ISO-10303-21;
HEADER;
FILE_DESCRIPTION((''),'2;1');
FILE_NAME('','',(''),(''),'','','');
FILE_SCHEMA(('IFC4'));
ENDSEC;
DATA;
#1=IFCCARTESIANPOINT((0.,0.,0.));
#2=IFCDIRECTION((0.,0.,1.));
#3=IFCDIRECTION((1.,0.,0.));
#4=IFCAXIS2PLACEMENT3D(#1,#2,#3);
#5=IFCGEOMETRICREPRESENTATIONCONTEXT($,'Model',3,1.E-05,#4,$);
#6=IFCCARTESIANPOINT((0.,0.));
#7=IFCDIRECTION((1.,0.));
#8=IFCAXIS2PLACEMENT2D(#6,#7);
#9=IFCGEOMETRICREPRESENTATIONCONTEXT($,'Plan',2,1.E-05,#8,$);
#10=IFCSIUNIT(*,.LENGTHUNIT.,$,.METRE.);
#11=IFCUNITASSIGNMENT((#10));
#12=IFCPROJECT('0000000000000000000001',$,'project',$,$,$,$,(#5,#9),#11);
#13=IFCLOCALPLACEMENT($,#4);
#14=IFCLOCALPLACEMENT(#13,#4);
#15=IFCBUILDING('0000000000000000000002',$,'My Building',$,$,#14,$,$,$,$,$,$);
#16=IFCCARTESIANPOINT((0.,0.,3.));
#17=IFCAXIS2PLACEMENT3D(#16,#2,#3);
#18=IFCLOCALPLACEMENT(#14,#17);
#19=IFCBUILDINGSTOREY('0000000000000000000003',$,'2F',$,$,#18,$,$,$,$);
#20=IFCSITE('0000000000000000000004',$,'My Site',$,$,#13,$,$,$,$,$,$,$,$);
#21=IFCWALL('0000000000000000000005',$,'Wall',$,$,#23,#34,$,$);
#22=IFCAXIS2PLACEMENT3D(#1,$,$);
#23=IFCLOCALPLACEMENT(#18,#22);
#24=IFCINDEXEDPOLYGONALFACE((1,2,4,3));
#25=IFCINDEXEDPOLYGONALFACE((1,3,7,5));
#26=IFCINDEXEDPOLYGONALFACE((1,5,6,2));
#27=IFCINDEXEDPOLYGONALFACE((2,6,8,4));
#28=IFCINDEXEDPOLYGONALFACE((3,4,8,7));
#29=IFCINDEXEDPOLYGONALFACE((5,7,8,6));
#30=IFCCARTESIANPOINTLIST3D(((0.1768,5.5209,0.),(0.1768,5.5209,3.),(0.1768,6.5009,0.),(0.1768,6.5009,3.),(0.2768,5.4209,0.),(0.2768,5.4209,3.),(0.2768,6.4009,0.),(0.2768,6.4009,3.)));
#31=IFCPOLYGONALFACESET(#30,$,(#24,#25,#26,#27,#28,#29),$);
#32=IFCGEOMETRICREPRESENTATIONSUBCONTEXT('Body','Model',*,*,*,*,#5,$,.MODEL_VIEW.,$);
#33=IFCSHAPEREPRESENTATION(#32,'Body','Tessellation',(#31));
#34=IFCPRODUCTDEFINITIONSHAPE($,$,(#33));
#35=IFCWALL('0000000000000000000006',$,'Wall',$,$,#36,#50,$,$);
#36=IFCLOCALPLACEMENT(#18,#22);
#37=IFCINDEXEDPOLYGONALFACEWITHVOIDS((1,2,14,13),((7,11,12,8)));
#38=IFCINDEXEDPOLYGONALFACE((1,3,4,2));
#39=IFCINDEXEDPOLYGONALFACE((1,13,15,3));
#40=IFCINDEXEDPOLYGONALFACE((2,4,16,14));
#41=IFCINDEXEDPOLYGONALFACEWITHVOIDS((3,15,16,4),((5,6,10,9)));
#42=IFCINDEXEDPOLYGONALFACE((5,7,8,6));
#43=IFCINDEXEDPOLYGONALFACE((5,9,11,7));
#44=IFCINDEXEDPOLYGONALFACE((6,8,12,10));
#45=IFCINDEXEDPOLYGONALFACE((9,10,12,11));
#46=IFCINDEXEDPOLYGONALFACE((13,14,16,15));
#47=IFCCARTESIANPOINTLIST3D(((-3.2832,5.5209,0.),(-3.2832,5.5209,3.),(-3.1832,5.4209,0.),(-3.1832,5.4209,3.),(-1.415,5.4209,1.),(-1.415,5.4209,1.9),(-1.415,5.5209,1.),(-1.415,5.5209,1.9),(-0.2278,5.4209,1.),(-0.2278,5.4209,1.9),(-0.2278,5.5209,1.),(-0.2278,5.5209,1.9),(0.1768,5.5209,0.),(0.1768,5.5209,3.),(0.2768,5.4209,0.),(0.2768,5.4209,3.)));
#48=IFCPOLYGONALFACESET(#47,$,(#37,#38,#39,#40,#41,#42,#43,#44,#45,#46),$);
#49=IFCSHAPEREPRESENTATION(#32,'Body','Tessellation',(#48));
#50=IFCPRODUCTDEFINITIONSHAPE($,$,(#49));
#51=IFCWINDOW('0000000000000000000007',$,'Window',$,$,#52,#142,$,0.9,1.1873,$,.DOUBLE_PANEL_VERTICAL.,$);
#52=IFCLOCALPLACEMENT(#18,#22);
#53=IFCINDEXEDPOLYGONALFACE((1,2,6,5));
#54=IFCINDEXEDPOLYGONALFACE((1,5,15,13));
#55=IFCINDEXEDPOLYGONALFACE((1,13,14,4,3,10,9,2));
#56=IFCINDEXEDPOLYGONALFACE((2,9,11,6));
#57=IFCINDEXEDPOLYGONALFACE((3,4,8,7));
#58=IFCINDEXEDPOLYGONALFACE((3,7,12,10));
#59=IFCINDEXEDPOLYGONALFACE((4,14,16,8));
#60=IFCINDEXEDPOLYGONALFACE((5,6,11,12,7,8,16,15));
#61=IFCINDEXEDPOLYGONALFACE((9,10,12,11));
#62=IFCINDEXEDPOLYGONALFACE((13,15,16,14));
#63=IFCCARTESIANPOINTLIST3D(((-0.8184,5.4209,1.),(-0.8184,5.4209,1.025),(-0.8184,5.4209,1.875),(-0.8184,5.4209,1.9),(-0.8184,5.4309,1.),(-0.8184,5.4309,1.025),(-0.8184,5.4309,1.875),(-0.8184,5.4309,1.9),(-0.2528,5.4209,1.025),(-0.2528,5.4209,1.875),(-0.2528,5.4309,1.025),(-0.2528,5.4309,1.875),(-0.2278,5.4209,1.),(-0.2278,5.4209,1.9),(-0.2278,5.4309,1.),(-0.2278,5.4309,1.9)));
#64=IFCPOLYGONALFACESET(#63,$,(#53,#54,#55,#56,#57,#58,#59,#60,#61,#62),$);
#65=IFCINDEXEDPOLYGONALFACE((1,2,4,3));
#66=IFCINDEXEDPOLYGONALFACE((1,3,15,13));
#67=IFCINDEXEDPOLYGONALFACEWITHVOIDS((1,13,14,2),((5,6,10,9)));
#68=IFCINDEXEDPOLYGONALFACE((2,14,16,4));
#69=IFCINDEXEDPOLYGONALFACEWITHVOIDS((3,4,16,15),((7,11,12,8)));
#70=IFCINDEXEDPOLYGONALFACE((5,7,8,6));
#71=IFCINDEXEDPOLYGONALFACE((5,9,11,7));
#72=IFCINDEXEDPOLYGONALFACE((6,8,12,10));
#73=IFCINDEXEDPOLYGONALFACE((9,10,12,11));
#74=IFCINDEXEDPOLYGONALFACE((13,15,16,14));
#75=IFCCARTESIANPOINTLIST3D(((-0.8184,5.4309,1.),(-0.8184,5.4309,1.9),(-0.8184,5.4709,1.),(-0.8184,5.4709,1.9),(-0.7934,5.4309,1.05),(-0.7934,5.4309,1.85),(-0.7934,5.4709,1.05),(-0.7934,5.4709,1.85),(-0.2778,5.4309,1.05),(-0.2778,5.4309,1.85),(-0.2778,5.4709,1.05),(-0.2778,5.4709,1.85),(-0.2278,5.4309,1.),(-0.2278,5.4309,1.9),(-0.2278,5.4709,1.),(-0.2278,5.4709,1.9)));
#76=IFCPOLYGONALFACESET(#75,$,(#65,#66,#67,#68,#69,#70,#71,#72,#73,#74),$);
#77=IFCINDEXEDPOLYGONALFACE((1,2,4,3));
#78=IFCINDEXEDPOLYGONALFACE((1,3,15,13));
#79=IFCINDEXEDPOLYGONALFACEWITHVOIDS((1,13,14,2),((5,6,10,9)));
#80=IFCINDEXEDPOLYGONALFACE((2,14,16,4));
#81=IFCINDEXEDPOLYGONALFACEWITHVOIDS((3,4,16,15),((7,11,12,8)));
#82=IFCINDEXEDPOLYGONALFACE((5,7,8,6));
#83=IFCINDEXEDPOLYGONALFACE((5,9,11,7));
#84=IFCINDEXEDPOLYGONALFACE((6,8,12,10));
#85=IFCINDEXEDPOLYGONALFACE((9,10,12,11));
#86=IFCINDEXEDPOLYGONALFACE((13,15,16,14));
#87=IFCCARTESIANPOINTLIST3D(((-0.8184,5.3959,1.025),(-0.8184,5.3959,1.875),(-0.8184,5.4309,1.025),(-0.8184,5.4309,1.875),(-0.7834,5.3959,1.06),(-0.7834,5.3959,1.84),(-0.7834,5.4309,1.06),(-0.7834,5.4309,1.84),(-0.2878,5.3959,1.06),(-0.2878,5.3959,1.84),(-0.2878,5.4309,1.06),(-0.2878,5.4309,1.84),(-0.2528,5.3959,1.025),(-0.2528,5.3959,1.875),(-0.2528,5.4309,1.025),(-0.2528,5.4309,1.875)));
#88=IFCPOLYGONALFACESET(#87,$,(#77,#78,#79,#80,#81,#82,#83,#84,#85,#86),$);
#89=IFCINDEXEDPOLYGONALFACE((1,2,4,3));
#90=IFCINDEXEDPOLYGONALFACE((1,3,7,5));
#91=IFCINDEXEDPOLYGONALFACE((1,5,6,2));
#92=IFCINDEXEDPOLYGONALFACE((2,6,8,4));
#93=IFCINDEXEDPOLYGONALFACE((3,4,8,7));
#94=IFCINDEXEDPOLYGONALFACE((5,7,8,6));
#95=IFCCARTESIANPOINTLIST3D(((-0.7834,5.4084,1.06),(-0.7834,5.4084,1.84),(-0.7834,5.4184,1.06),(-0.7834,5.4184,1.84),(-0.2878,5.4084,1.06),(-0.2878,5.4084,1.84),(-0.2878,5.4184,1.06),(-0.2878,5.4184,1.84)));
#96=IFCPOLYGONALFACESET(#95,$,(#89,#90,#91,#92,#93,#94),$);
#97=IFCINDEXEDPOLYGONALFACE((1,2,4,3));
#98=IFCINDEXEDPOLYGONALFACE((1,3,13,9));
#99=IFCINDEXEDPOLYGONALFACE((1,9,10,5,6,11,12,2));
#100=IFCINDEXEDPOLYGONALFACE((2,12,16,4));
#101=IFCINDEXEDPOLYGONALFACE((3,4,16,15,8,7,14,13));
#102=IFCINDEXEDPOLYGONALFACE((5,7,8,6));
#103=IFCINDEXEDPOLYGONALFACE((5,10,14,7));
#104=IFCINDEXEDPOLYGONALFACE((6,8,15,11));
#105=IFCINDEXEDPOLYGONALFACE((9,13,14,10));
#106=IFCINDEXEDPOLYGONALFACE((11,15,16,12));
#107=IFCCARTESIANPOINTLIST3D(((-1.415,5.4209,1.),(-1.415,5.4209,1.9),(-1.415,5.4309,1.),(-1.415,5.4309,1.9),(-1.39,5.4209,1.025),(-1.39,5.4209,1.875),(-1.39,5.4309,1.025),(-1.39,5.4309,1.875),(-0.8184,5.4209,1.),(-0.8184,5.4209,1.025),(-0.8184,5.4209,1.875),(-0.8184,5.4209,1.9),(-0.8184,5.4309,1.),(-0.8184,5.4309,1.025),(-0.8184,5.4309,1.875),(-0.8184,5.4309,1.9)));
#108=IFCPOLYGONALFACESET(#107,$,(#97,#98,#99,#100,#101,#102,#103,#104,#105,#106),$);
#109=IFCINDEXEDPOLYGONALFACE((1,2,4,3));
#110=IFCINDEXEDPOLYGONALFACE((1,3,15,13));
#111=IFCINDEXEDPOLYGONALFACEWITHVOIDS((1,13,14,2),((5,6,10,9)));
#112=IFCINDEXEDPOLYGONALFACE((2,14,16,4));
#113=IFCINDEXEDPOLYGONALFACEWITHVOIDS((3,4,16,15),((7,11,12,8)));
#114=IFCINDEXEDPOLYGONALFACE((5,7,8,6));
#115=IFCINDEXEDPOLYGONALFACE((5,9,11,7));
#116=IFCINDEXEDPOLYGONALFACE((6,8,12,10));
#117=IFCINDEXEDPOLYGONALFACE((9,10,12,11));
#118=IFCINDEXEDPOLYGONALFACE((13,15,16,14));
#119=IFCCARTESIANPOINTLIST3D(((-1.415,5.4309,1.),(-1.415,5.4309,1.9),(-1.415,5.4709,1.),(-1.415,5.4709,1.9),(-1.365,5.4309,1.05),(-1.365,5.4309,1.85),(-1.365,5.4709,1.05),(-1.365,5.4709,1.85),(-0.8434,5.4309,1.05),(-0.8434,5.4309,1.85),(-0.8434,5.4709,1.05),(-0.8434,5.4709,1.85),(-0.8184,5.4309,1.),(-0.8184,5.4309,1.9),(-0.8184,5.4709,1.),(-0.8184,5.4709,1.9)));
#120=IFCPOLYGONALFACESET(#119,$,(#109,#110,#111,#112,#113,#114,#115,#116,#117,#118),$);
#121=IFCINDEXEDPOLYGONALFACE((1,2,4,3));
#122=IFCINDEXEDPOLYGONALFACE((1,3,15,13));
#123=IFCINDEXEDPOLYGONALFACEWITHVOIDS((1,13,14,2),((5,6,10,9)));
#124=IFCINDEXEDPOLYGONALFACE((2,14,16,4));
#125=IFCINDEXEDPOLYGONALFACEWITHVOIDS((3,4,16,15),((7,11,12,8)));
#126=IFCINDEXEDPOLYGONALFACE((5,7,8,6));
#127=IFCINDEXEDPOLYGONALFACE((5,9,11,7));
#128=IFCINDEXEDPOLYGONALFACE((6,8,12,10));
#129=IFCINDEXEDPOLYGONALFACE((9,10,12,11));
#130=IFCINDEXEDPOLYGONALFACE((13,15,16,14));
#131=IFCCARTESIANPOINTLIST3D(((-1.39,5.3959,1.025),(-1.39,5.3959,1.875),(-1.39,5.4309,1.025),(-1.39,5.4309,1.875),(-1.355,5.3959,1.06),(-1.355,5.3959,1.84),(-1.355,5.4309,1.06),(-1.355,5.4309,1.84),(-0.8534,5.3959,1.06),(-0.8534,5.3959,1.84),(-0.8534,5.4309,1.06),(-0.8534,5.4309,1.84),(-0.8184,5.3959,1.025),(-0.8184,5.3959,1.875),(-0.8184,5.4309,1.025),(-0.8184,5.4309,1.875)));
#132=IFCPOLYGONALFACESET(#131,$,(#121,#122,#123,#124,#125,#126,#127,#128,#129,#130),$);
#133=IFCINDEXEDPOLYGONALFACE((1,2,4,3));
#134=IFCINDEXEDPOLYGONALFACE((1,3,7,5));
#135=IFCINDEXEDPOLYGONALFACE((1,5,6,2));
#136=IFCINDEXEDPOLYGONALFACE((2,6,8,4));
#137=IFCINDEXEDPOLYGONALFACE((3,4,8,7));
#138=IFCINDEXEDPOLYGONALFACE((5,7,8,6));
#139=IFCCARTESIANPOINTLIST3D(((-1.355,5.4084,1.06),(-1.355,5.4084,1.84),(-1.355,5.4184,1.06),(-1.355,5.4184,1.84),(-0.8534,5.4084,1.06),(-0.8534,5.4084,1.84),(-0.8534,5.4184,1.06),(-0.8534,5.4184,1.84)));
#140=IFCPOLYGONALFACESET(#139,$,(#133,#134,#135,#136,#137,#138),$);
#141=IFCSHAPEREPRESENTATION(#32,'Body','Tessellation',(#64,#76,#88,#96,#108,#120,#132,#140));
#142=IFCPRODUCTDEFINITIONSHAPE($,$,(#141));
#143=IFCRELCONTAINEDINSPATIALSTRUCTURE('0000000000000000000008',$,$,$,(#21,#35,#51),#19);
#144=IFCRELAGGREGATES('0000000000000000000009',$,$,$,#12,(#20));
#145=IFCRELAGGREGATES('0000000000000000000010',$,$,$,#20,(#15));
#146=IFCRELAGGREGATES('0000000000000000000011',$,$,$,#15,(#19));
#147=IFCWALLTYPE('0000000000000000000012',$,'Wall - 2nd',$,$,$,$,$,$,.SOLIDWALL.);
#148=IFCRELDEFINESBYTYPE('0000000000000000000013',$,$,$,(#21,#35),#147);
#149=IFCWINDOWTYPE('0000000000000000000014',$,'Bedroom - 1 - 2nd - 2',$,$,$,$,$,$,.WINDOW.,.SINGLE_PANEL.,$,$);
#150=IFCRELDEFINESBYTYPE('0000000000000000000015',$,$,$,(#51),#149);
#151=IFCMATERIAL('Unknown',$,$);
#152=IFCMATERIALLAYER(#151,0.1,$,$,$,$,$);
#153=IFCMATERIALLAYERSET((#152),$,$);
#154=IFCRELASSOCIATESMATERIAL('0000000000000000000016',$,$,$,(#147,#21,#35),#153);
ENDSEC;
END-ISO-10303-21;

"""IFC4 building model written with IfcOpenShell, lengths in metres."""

from ifc_helpers import new_model, entity, si_unit, frame, origin_with_axes, origin_2d_with_axis, place, context, subcontext, project, spatial, line, indexed_curve, outline, extrude, shape, source, transform, mapped, material, layer, layer_set, layer_usage, type_object, type_shapes, element, fill, save


model = new_model("IFC4")

# Units and contexts
model_context = context("Model", 3, precision=1e-05, world=origin_with_axes())
plan_context = context("Plan", 2, precision=1e-05, world=origin_2d_with_axis())
body_context_1 = subcontext(model_context, "Body", "Model", "MODEL_VIEW")
body_context_2 = subcontext(plan_context, "Body", "Plan", "PLAN_VIEW")
ifc_project = project(units=[si_unit("LENGTHUNIT", "METRE")], contexts=[model_context, plan_context])

# Site, building, storey
site_placement = place(None, origin_with_axes())
site = spatial("IfcSite", under=ifc_project, at=site_placement, Name="My Site")
building_placement = place(site_placement, origin_with_axes())
building = spatial("IfcBuilding", under=site, at=building_placement, Name="My Building")
storey_placement = place(building_placement, frame((0.0, 0.0, 3.0), z_axis=(0.0, 0.0, 1.0), x_axis=(1.0, 0.0, 0.0)))
storey = spatial("IfcBuildingStorey", under=building, at=storey_placement, Name="2F")

# Shared definitions
ifc_material = material(Name="Unknown")

# Shared definitions
ifc_layer_1 = layer(ifc_material, 0.1)
ifc_layer_set_1 = layer_set([ifc_layer_1])
wall_type = type_object("IfcWallType", Name="Wall - 2nd", PredefinedType="SOLIDWALL", material=ifc_layer_set_1)

# Wall
ifc_layer_usage_1 = layer_usage(ifc_layer_set_1, "AXIS2", "POSITIVE", 0.0)
wall_1_placement = place(storey_placement, frame((0.1768, 6.5009, 0.0), z_axis=(0.0, 0.0, 1.0), x_axis=(0.0, -1.0, 0.0)))
element("IfcWall", 1, at=wall_1_placement, inside=storey, type_object=wall_type, material=ifc_layer_usage_1, Name="Wall", context=body_context_1, shape_type="SweptSolid", body=[
    extrude(outline(indexed_curve([(0.0, 0.0), (0.1, 0.1), (1.08, 0.1), (0.98, 0.0)], segments=[line(1, 2, 3, 4, 1)])), origin_with_axes(), (0.0, 0.0, 1.0), 3.0),
])

# Wall, opening, window
ifc_layer_usage_2 = layer_usage(ifc_layer_set_1, "AXIS2", "POSITIVE", 0.0)
wall_2_placement = place(storey_placement, frame((0.1768, 5.5209, 0.0), z_axis=(0.0, 0.0, 1.0), x_axis=(-1.0, 0.0, 0.0)))
wall_2 = element("IfcWall", 2, at=wall_2_placement, inside=storey, type_object=wall_type, material=ifc_layer_usage_2, Name="Wall", context=body_context_1, shape_type="SweptSolid", body=[
    extrude(outline(indexed_curve([(0.0, 0.0), (-0.1, 0.1), (3.36, 0.1), (3.46, 0.0)], segments=[line(1, 2, 3, 4, 1)])), origin_with_axes(), (0.0, 0.0, 1.0), 3.0),
])
shared_shape_1 = source(origin_with_axes(), body_context_1, "Body", "SweptSolid", [
    extrude(outline(indexed_curve([(0.0, 0.0), (1.1873, 0.0), (1.1873, 0.9), (0.0, 0.9)], segments=[line(1, 2, 3, 4, 1)])), frame((0.0, -0.6, 0.0), z_axis=(0.0, -1.0, 0.0), x_axis=(1.0, 0.0, 0.0)), (0.0, 0.0, -1.0), 1.2),
])
opening_1_placement = place(wall_2_placement, frame((0.4046, 0.0, 1.0), z_axis=(0.0, 0.0, 1.0), x_axis=(1.0, 0.0, 0.0)))
opening_1 = element("IfcOpeningElement", 3, at=opening_1_placement, cuts=wall_2, PredefinedType="OPENING", context=body_context_1, shape_type="MappedRepresentation", body=[
    mapped(shared_shape_1, transform((0.0, 0.0, 0.0), x_axis=(1.0, 0.0, 0.0), y_axis=(0.0, 1.0, 0.0), z_axis=(0.0, 0.0, 1.0), scale=1.0)),
])
window_type_1 = type_object("IfcWindowType", Name="Bedroom - 1 - 2nd - 2", PartitioningType="SINGLE_PANEL", PredefinedType="WINDOW")
shared_shape_2 = source(origin_with_axes(), body_context_1, "Body", "SweptSolid", [
    extrude(outline(indexed_curve([(0.5907, 0.0), (0.0, 0.0), (0.0, 0.9), (0.5907, 0.9), (0.5907, 0.875), (0.025, 0.875), (0.025, 0.025), (0.5907, 0.025)], segments=[line(1, 2, 3, 4, 5, 6, 7, 8, 1)])), frame((0.0, 0.09, 0.0), z_axis=(0.0, -1.0, 0.0), x_axis=(1.0, 0.0, 0.0)), (0.0, 0.0, -1.0), 0.01),
    extrude(outline(indexed_curve([(0.0, 0.0), (0.5907, 0.0), (0.5907, 0.9), (0.0, 0.9)], segments=[line(1, 2, 3, 4, 1)]), holes=[indexed_curve([(0.05, 0.05), (0.5657, 0.05), (0.5657, 0.85), (0.05, 0.85)], segments=[line(1, 2, 3, 4, 1)])]), frame((0.0, 0.05, 0.0), z_axis=(0.0, -1.0, 0.0), x_axis=(1.0, 0.0, 0.0)), (0.0, 0.0, -1.0), 0.04),
    extrude(outline(indexed_curve([(0.0, 0.0), (0.5657, 0.0), (0.5657, 0.85), (0.0, 0.85)], segments=[line(1, 2, 3, 4, 1)]), holes=[indexed_curve([(0.035, 0.035), (0.5307, 0.035), (0.5307, 0.815), (0.035, 0.815)], segments=[line(1, 2, 3, 4, 1)])]), frame((0.025, 0.09, 0.025), z_axis=(0.0, -1.0, 0.0), x_axis=(1.0, 0.0, 0.0)), (0.0, 0.0, -1.0), 0.035),
    extrude(outline(indexed_curve([(0.035, 0.035), (0.5307, 0.035), (0.5307, 0.815), (0.035, 0.815)], segments=[line(1, 2, 3, 4, 1)])), frame((0.025, 0.1025, 0.025), z_axis=(0.0, -1.0, 0.0), x_axis=(1.0, 0.0, 0.0)), (0.0, 0.0, -1.0), 0.01),
    extrude(outline(indexed_curve([(0.0, 0.9), (0.5966, 0.9), (0.5966, 0.0), (0.0, 0.0), (0.0, 0.025), (0.5716, 0.025), (0.5716, 0.875), (0.0, 0.875)], segments=[line(1, 2, 3, 4, 5, 6, 7, 8, 1)])), frame((0.5907, 0.09, 0.0), z_axis=(0.0, -1.0, 0.0), x_axis=(1.0, 0.0, 0.0)), (0.0, 0.0, -1.0), 0.01),
    extrude(outline(indexed_curve([(0.0, 0.0), (0.5966, 0.0), (0.5966, 0.9), (0.0, 0.9)], segments=[line(1, 2, 3, 4, 1)]), holes=[indexed_curve([(0.025, 0.05), (0.5466, 0.05), (0.5466, 0.85), (0.025, 0.85)], segments=[line(1, 2, 3, 4, 1)])]), frame((0.5907, 0.05, 0.0), z_axis=(0.0, -1.0, 0.0), x_axis=(1.0, 0.0, 0.0)), (0.0, 0.0, -1.0), 0.04),
    extrude(outline(indexed_curve([(0.0, 0.0), (0.5716, 0.0), (0.5716, 0.85), (0.0, 0.85)], segments=[line(1, 2, 3, 4, 1)]), holes=[indexed_curve([(0.035, 0.035), (0.5366, 0.035), (0.5366, 0.815), (0.035, 0.815)], segments=[line(1, 2, 3, 4, 1)])]), frame((0.5907, 0.09, 0.025), z_axis=(0.0, -1.0, 0.0), x_axis=(1.0, 0.0, 0.0)), (0.0, 0.0, -1.0), 0.035),
    extrude(outline(indexed_curve([(0.035, 0.035), (0.5366, 0.035), (0.5366, 0.815), (0.035, 0.815)], segments=[line(1, 2, 3, 4, 1)])), frame((0.5907, 0.1025, 0.025), z_axis=(0.0, -1.0, 0.0), x_axis=(1.0, 0.0, 0.0)), (0.0, 0.0, -1.0), 0.01),
])
shared_shape_3 = source(origin_with_axes(), body_context_2, "Body", "Curve2D", [
    entity("IfcIndexedPolyCurve", entity("IfcCartesianPointList2D", [[0.05, 0.05], [0.5657, 0.05]])),
    entity("IfcIndexedPolyCurve", entity("IfcCartesianPointList2D", [[0.0, 0.1], [0.025, 0.1], [0.025, 0.09], [0.05, 0.09], [0.05, 0.05], [0.0, 0.05]]), [entity("IfcLineIndex", [1, 2, 3, 4, 5, 6, 1])]),
    entity("IfcIndexedPolyCurve", entity("IfcCartesianPointList2D", [[0.5907, 0.1], [0.5907, 0.1], [0.5907, 0.09], [0.5657, 0.09], [0.5657, 0.05], [0.5907, 0.05]])),
    entity("IfcIndexedPolyCurve", entity("IfcCartesianPointList2D", [[0.025, 0.09], [0.06, 0.09], [0.06, 0.125], [0.025, 0.125]]), [entity("IfcLineIndex", [1, 2, 3, 4, 1])]),
    entity("IfcIndexedPolyCurve", entity("IfcCartesianPointList2D", [[0.5907, 0.09], [0.5557, 0.09], [0.5557, 0.125], [0.5907, 0.125]]), [entity("IfcLineIndex", [1, 2, 3, 4, 1])]),
    entity("IfcIndexedPolyCurve", entity("IfcCartesianPointList2D", [[0.06, 0.09], [0.5557, 0.09]])),
    entity("IfcIndexedPolyCurve", entity("IfcCartesianPointList2D", [[0.06, 0.125], [0.5557, 0.125]])),
    entity("IfcIndexedPolyCurve", entity("IfcCartesianPointList2D", [[0.06, 0.1075], [0.5557, 0.1075]])),
    entity("IfcIndexedPolyCurve", entity("IfcCartesianPointList2D", [[0.6157, 0.05], [1.1373, 0.05]])),
    entity("IfcIndexedPolyCurve", entity("IfcCartesianPointList2D", [[0.5907, 0.1], [0.5907, 0.1], [0.5907, 0.09], [0.6157, 0.09], [0.6157, 0.05], [0.5907, 0.05]])),
    entity("IfcIndexedPolyCurve", entity("IfcCartesianPointList2D", [[1.1873, 0.1], [1.1623, 0.1], [1.1623, 0.09], [1.1373, 0.09], [1.1373, 0.05], [1.1873, 0.05]]), [entity("IfcLineIndex", [1, 2, 3, 4, 5, 6, 1])]),
    entity("IfcIndexedPolyCurve", entity("IfcCartesianPointList2D", [[0.5907, 0.09], [0.6257, 0.09], [0.6257, 0.125], [0.5907, 0.125]]), [entity("IfcLineIndex", [1, 2, 3, 4, 1])]),
    entity("IfcIndexedPolyCurve", entity("IfcCartesianPointList2D", [[1.1623, 0.09], [1.1273, 0.09], [1.1273, 0.125], [1.1623, 0.125]]), [entity("IfcLineIndex", [1, 2, 3, 4, 1])]),
    entity("IfcIndexedPolyCurve", entity("IfcCartesianPointList2D", [[0.6257, 0.09], [1.1273, 0.09]])),
    entity("IfcIndexedPolyCurve", entity("IfcCartesianPointList2D", [[0.6257, 0.125], [1.1273, 0.125]])),
    entity("IfcIndexedPolyCurve", entity("IfcCartesianPointList2D", [[0.6257, 0.1075], [1.1273, 0.1075]])),
])
type_shapes(window_type_1, [shared_shape_2, shared_shape_3])
window_1_placement = place(opening_1_placement, origin_with_axes())
window_1 = element("IfcWindow", 4, at=window_1_placement, inside=storey, type_object=window_type_1, Name="Window", OverallHeight=0.9, OverallWidth=1.1873, PartitioningType="DOUBLE_PANEL_VERTICAL", shapes=[
    shape(body_context_1, "Body", "MappedRepresentation", [mapped(shared_shape_2, transform((0.0, 0.0, 0.0), x_axis=(1.0, 0.0, 0.0), y_axis=(0.0, 1.0, 0.0), z_axis=(0.0, 0.0, 1.0), scale=1.0))]),
    shape(body_context_2, "Body", "MappedRepresentation", [mapped(shared_shape_3, transform((0.0, 0.0, 0.0), x_axis=(1.0, 0.0, 0.0), y_axis=(0.0, 1.0, 0.0), z_axis=(0.0, 0.0, 1.0), scale=1.0))]),
])
fill(opening_1, window_1)

save(model, "model.ifc")
